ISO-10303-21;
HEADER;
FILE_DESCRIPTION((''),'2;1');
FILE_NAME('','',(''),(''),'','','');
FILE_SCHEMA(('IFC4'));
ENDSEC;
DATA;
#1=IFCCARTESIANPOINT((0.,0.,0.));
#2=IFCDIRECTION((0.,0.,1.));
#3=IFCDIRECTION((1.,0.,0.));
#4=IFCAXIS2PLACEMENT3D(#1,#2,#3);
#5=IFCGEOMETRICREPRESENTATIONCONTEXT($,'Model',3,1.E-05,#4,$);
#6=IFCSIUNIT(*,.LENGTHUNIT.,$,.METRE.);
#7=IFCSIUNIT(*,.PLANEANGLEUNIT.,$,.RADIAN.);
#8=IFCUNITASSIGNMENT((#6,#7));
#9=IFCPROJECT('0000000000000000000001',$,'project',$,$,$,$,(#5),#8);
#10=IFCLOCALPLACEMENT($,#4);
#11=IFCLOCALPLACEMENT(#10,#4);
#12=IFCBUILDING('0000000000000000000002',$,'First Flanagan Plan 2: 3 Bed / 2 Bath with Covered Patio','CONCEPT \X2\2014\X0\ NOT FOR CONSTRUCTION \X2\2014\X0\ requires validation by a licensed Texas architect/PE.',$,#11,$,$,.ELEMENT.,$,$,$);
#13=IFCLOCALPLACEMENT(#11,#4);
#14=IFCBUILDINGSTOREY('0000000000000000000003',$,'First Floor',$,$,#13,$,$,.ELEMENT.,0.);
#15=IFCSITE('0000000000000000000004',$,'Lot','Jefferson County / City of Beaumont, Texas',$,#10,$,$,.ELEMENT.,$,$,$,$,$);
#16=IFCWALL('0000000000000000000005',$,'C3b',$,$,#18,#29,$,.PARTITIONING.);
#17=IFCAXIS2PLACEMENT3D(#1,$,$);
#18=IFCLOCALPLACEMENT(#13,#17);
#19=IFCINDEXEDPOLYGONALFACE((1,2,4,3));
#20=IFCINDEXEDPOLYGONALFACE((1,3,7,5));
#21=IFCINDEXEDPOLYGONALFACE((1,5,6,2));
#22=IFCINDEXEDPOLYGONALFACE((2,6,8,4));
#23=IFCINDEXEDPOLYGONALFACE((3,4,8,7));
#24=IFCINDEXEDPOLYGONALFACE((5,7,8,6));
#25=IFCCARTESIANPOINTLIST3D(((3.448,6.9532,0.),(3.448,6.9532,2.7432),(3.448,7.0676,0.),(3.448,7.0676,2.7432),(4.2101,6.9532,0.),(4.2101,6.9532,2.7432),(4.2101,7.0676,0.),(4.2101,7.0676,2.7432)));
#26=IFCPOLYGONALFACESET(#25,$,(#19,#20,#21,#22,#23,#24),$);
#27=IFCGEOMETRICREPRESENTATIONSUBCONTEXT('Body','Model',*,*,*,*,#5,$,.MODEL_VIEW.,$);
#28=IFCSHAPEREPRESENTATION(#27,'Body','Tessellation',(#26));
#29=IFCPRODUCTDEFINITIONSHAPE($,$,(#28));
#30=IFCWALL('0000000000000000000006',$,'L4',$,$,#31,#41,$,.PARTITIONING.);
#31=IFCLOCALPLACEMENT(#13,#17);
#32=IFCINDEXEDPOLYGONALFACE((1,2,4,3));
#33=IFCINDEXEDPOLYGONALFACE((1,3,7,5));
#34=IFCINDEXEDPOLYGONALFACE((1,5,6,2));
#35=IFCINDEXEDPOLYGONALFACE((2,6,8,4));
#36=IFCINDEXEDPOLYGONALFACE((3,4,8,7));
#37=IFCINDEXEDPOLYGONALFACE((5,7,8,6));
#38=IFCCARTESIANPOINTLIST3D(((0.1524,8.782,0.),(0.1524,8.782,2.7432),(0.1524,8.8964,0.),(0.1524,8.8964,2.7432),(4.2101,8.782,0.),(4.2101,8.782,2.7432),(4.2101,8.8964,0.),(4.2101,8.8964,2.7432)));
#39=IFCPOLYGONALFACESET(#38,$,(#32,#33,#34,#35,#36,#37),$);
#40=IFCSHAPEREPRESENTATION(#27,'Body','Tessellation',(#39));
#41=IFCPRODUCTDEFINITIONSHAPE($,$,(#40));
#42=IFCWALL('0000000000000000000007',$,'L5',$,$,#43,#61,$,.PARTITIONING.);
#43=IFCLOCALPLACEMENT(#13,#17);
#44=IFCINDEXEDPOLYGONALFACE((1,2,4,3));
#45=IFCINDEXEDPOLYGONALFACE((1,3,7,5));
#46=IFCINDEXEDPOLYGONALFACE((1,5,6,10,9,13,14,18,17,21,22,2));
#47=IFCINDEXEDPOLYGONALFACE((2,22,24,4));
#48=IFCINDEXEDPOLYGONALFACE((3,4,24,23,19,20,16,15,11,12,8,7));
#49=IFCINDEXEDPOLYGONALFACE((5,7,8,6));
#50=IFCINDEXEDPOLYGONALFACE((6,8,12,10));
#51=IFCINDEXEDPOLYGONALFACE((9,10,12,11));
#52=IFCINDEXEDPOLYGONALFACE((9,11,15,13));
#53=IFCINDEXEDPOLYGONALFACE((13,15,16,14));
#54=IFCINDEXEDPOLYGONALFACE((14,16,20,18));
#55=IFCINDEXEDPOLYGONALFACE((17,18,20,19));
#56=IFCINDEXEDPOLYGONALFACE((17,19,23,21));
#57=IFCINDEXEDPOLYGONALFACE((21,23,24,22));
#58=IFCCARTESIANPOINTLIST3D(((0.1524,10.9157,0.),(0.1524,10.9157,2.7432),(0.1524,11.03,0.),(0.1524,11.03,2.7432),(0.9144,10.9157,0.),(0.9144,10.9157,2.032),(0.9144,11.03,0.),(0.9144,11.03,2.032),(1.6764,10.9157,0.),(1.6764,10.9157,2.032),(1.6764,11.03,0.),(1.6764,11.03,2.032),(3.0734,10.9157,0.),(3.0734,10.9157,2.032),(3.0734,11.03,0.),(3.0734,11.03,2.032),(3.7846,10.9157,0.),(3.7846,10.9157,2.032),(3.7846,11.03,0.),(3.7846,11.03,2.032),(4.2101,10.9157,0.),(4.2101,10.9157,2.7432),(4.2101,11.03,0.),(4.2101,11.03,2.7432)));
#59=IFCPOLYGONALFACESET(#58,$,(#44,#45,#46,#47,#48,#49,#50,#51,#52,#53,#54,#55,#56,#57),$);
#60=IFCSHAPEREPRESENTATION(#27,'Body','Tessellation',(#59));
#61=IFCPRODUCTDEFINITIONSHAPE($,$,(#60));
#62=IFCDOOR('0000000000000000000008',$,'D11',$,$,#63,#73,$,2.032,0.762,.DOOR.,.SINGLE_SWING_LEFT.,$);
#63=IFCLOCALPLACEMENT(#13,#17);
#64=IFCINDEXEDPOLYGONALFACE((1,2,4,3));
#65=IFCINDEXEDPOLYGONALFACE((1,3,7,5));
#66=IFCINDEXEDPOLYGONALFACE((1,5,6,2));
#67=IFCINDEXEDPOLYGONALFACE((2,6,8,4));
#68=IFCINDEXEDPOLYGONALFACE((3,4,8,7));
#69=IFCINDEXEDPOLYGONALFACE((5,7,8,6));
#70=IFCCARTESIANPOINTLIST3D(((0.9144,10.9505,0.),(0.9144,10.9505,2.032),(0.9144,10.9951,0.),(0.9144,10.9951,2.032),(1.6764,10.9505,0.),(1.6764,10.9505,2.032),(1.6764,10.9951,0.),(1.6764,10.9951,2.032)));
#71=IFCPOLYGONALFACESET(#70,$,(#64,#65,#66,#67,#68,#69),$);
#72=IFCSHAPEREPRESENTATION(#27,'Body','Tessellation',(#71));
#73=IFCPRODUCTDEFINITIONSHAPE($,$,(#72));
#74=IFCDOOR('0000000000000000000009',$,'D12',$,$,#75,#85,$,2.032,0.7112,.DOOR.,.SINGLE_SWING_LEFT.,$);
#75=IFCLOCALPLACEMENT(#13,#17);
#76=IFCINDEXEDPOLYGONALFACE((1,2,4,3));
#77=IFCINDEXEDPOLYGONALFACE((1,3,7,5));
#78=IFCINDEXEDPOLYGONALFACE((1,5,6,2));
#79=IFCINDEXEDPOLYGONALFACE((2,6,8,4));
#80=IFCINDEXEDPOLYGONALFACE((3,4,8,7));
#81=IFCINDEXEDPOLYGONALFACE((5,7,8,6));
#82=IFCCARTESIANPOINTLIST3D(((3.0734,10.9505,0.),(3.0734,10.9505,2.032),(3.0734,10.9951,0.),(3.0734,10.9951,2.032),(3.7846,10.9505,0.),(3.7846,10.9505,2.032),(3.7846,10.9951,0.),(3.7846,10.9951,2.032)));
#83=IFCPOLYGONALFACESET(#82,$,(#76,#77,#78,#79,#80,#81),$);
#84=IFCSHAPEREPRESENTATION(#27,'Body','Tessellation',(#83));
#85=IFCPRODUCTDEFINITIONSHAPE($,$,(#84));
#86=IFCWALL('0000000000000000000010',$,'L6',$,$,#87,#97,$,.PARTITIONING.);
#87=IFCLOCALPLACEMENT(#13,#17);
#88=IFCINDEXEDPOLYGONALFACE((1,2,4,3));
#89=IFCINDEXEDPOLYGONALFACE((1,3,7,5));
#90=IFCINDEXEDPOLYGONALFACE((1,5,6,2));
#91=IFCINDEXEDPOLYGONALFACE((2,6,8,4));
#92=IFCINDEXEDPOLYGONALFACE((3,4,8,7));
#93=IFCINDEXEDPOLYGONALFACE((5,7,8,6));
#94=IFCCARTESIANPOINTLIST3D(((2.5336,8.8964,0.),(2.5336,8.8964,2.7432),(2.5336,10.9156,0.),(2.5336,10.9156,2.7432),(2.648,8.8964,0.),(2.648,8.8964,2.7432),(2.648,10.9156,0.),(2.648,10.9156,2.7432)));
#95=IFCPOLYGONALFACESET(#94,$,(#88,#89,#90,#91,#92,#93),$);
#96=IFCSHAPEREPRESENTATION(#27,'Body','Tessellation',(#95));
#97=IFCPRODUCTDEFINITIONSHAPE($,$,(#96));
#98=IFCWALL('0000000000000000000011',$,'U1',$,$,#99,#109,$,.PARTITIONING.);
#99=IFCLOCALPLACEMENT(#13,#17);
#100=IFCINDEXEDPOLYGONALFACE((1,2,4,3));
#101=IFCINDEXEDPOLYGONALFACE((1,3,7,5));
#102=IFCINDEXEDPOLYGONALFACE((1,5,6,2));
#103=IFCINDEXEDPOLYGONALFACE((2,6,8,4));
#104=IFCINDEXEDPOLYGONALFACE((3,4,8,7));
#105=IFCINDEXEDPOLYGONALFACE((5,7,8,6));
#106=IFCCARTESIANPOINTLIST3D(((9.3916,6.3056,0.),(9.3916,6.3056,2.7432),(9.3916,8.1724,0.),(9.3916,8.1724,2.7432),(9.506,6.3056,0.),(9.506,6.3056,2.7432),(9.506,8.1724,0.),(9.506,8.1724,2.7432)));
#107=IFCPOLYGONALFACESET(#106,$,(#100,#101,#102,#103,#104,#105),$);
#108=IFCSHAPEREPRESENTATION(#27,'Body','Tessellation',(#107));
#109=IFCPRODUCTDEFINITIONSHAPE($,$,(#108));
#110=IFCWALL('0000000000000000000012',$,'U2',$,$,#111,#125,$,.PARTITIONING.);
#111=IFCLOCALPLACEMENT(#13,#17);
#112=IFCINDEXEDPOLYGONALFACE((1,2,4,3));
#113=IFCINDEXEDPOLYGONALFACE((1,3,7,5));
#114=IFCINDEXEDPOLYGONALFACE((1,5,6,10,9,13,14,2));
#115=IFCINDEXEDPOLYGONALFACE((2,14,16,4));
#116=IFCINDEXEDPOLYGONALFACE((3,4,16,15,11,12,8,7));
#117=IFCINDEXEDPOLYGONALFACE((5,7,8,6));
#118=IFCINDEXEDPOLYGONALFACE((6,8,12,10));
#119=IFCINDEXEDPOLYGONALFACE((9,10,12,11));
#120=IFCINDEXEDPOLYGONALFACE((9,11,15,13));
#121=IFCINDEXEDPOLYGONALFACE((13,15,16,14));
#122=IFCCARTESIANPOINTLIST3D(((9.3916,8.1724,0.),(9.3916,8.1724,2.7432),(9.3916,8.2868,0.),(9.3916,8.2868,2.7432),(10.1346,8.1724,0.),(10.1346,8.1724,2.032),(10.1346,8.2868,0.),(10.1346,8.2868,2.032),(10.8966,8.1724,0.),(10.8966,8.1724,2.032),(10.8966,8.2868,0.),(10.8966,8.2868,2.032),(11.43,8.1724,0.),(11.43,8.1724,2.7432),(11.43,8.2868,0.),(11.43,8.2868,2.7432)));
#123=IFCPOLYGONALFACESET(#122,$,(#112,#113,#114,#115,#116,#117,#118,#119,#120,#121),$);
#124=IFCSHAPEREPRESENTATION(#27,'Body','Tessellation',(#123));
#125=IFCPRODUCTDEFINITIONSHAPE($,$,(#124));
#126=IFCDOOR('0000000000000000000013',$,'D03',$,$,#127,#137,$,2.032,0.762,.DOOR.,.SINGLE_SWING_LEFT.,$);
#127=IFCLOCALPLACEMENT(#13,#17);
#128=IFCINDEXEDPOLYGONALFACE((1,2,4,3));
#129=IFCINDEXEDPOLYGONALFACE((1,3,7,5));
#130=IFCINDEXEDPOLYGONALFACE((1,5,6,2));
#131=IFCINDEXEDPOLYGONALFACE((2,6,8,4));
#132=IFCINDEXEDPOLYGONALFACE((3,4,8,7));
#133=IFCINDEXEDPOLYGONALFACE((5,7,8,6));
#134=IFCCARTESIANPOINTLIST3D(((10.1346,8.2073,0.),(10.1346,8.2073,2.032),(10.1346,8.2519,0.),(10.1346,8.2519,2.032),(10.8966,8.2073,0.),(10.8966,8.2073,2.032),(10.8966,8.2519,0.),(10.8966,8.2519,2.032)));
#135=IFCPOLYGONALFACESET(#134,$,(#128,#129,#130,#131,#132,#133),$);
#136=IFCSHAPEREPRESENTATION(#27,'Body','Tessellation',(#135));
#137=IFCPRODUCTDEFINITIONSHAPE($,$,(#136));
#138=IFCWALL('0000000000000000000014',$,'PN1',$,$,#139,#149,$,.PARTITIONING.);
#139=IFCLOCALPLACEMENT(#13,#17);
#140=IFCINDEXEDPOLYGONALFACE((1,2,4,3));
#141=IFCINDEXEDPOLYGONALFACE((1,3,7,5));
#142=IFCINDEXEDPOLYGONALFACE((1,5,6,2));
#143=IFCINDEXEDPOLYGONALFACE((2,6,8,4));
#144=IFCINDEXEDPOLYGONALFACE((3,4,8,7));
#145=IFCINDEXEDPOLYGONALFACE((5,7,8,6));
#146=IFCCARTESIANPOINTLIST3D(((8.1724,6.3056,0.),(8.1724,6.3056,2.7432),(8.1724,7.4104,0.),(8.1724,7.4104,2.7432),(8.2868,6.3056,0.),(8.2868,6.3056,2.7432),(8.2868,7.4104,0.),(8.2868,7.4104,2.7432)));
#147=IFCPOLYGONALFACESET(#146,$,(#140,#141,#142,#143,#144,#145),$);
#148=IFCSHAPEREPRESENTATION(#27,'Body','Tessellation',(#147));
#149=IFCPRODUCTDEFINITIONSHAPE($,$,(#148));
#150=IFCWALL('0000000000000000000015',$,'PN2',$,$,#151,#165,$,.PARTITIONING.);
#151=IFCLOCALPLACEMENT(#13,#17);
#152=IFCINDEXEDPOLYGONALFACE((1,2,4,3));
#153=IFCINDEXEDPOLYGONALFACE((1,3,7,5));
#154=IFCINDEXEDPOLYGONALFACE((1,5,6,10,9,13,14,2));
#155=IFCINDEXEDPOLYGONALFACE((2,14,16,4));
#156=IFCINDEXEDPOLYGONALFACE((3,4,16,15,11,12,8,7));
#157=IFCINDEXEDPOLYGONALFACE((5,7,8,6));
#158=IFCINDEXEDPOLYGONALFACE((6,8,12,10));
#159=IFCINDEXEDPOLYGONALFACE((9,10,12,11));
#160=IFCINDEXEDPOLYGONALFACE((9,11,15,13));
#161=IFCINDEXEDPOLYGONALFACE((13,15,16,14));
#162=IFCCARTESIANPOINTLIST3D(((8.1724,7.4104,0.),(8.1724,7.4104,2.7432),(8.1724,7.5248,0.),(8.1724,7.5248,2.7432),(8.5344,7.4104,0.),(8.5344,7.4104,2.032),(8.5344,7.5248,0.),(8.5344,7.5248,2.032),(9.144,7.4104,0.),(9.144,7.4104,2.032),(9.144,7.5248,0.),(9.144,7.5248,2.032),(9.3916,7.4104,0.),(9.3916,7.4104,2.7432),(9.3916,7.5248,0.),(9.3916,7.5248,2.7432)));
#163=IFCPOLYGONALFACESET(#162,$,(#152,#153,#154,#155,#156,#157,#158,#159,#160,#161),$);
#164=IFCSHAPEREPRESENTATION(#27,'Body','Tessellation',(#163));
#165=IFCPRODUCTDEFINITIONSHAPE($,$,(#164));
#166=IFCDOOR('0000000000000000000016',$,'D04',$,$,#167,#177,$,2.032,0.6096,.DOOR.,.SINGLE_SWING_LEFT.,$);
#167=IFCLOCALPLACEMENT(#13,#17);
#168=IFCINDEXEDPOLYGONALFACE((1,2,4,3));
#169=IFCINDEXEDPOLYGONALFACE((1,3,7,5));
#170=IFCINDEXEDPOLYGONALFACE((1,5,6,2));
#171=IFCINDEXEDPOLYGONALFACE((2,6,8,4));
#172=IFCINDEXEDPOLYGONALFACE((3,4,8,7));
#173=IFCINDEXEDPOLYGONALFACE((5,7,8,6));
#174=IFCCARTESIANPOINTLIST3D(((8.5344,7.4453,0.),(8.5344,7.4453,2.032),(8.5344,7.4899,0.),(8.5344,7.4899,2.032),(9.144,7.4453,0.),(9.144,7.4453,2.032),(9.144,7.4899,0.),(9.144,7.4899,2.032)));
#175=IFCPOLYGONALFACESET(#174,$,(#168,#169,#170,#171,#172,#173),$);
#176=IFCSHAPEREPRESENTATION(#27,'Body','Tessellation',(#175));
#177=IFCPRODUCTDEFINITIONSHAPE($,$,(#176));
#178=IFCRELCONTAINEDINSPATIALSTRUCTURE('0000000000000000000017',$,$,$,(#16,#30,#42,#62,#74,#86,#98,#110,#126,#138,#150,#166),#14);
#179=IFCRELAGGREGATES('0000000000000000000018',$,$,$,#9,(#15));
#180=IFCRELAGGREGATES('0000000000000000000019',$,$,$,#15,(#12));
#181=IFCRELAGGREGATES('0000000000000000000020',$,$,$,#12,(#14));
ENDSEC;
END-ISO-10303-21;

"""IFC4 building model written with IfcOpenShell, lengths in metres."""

from ifc_helpers import new_model, si_unit, frame, frame_2d, origin_with_axes, place, context, subcontext, project, spatial, rectangle, extrude, element, fill, save


model = new_model("IFC4")

# Units and contexts
model_context = context("Model", 3, precision=1e-05, world=origin_with_axes())
body_context = subcontext(model_context, "Body", "Model", "MODEL_VIEW")
ifc_project = project(units=[si_unit("LENGTHUNIT", "METRE"), si_unit("PLANEANGLEUNIT", "RADIAN")], contexts=[model_context])

# Site, building, storey
site_placement = place(None, origin_with_axes())
site = spatial("IfcSite", under=ifc_project, at=site_placement, Name="Lot", Description="Jefferson County / City of Beaumont, Texas", CompositionType="ELEMENT")
building_placement = place(site_placement, origin_with_axes())
building = spatial("IfcBuilding", under=site, at=building_placement, Name="First Flanagan Plan 2: 3 Bed / 2 Bath with Covered Patio", Description="CONCEPT — NOT FOR CONSTRUCTION — requires validation by a licensed Texas architect/PE.", CompositionType="ELEMENT")
storey_placement = place(building_placement, origin_with_axes())
storey = spatial("IfcBuildingStorey", under=building, at=storey_placement, Name="First Floor", CompositionType="ELEMENT", Elevation=0.0)

# Walls
wall_1_placement = place(storey_placement, frame((3.4481, 7.0104, 0.0), z_axis=(0.0, 0.0, 1.0), x_axis=(1.0, 0.0, 0.0)))
element("IfcWall", 1, at=wall_1_placement, inside=storey, Name="C3b", PredefinedType="PARTITIONING", context=body_context, shape_type="SweptSolid", body=[
    extrude(rectangle(XDim=0.762, YDim=0.1143, at=frame_2d((0.381, 0.0), x_axis=(1.0, 0.0))), origin_with_axes(), (0.0, 0.0, 1.0), 2.7432),
])
wall_2_placement = place(storey_placement, frame((0.1524, 8.8392, 0.0), z_axis=(0.0, 0.0, 1.0), x_axis=(1.0, 0.0, 0.0)))
element("IfcWall", 2, at=wall_2_placement, inside=storey, Name="L4", PredefinedType="PARTITIONING", context=body_context, shape_type="SweptSolid", body=[
    extrude(rectangle(XDim=4.0577, YDim=0.1143, at=frame_2d((2.0288, 0.0), x_axis=(1.0, 0.0))), origin_with_axes(), (0.0, 0.0, 1.0), 2.7432),
])

# Wall, openings, doors
wall_3_placement = place(storey_placement, frame((0.1524, 10.9728, 0.0), z_axis=(0.0, 0.0, 1.0), x_axis=(1.0, 0.0, 0.0)))
wall_3 = element("IfcWall", 3, at=wall_3_placement, inside=storey, Name="L5", PredefinedType="PARTITIONING", context=body_context, shape_type="SweptSolid", body=[
    extrude(rectangle(XDim=4.0577, YDim=0.1143, at=frame_2d((2.0288, 0.0), x_axis=(1.0, 0.0))), origin_with_axes(), (0.0, 0.0, 1.0), 2.7432),
])
opening_1_placement = place(wall_3_placement, frame((0.762, 0.0, 0.0), z_axis=(0.0, 0.0, 1.0), x_axis=(1.0, 0.0, 0.0)))
opening_1 = element("IfcOpeningElement", 4, at=opening_1_placement, cuts=wall_3, PredefinedType="OPENING", context=body_context, shape_type="SweptSolid", body=[
    extrude(rectangle(XDim=0.762, YDim=0.1448, at=frame_2d((0.381, 0.0), x_axis=(1.0, 0.0))), origin_with_axes(), (0.0, 0.0, 1.0), 2.032),
])
opening_2_placement = place(wall_3_placement, frame((2.921, 0.0, 0.0), z_axis=(0.0, 0.0, 1.0), x_axis=(1.0, 0.0, 0.0)))
opening_2 = element("IfcOpeningElement", 5, at=opening_2_placement, cuts=wall_3, PredefinedType="OPENING", context=body_context, shape_type="SweptSolid", body=[
    extrude(rectangle(XDim=0.7112, YDim=0.1448, at=frame_2d((0.3556, 0.0), x_axis=(1.0, 0.0))), origin_with_axes(), (0.0, 0.0, 1.0), 2.032),
])
door_1_placement = place(opening_1_placement, origin_with_axes())
door_1 = element("IfcDoor", 6, at=door_1_placement, inside=storey, Name="D11", OperationType="SINGLE_SWING_LEFT", OverallHeight=2.032, OverallWidth=0.762, PredefinedType="DOOR", context=body_context, shape_type="SweptSolid", body=[
    extrude(rectangle(XDim=0.762, YDim=0.0445, at=frame_2d((0.381, 0.0), x_axis=(1.0, 0.0))), origin_with_axes(), (0.0, 0.0, 1.0), 2.032),
])
fill(opening_1, door_1)
door_2_placement = place(opening_2_placement, origin_with_axes())
door_2 = element("IfcDoor", 7, at=door_2_placement, inside=storey, Name="D12", OperationType="SINGLE_SWING_LEFT", OverallHeight=2.032, OverallWidth=0.7112, PredefinedType="DOOR", context=body_context, shape_type="SweptSolid", body=[
    extrude(rectangle(XDim=0.7112, YDim=0.0445, at=frame_2d((0.3556, 0.0), x_axis=(1.0, 0.0))), origin_with_axes(), (0.0, 0.0, 1.0), 2.032),
])
fill(opening_2, door_2)

# Walls
wall_4_placement = place(storey_placement, frame((2.5908, 8.8963, 0.0), z_axis=(0.0, 0.0, 1.0), x_axis=(0.0, 1.0, 0.0)))
element("IfcWall", 8, at=wall_4_placement, inside=storey, Name="L6", PredefinedType="PARTITIONING", context=body_context, shape_type="SweptSolid", body=[
    extrude(rectangle(XDim=2.0193, YDim=0.1143, at=frame_2d((1.0097, 0.0), x_axis=(1.0, 0.0))), origin_with_axes(), (0.0, 0.0, 1.0), 2.7432),
])
wall_5_placement = place(storey_placement, frame((9.4488, 6.3056, 0.0), z_axis=(0.0, 0.0, 1.0), x_axis=(0.0, 1.0, 0.0)))
element("IfcWall", 9, at=wall_5_placement, inside=storey, Name="U1", PredefinedType="PARTITIONING", context=body_context, shape_type="SweptSolid", body=[
    extrude(rectangle(XDim=1.8669, YDim=0.1143, at=frame_2d((0.9335, 0.0), x_axis=(1.0, 0.0))), origin_with_axes(), (0.0, 0.0, 1.0), 2.7432),
])

# Wall, opening, door
wall_6_placement = place(storey_placement, frame((9.3917, 8.2296, 0.0), z_axis=(0.0, 0.0, 1.0), x_axis=(1.0, 0.0, 0.0)))
wall_6 = element("IfcWall", 10, at=wall_6_placement, inside=storey, Name="U2", PredefinedType="PARTITIONING", context=body_context, shape_type="SweptSolid", body=[
    extrude(rectangle(XDim=2.0383, YDim=0.1143, at=frame_2d((1.0192, 0.0), x_axis=(1.0, 0.0))), origin_with_axes(), (0.0, 0.0, 1.0), 2.7432),
])
opening_3_placement = place(wall_6_placement, frame((0.7429, 0.0, 0.0), z_axis=(0.0, 0.0, 1.0), x_axis=(1.0, 0.0, 0.0)))
opening_3 = element("IfcOpeningElement", 11, at=opening_3_placement, cuts=wall_6, PredefinedType="OPENING", context=body_context, shape_type="SweptSolid", body=[
    extrude(rectangle(XDim=0.762, YDim=0.1448, at=frame_2d((0.381, 0.0), x_axis=(1.0, 0.0))), origin_with_axes(), (0.0, 0.0, 1.0), 2.032),
])
door_3_placement = place(opening_3_placement, origin_with_axes())
door_3 = element("IfcDoor", 12, at=door_3_placement, inside=storey, Name="D03", OperationType="SINGLE_SWING_LEFT", OverallHeight=2.032, OverallWidth=0.762, PredefinedType="DOOR", context=body_context, shape_type="SweptSolid", body=[
    extrude(rectangle(XDim=0.762, YDim=0.0445, at=frame_2d((0.381, 0.0), x_axis=(1.0, 0.0))), origin_with_axes(), (0.0, 0.0, 1.0), 2.032),
])
fill(opening_3, door_3)

# Wall
wall_7_placement = place(storey_placement, frame((8.2296, 6.3056, 0.0), z_axis=(0.0, 0.0, 1.0), x_axis=(0.0, 1.0, 0.0)))
element("IfcWall", 13, at=wall_7_placement, inside=storey, Name="PN1", PredefinedType="PARTITIONING", context=body_context, shape_type="SweptSolid", body=[
    extrude(rectangle(XDim=1.1049, YDim=0.1143, at=frame_2d((0.5524, 0.0), x_axis=(1.0, 0.0))), origin_with_axes(), (0.0, 0.0, 1.0), 2.7432),
])

# Wall, opening, door
wall_8_placement = place(storey_placement, frame((8.1724, 7.4676, 0.0), z_axis=(0.0, 0.0, 1.0), x_axis=(1.0, 0.0, 0.0)))
wall_8 = element("IfcWall", 14, at=wall_8_placement, inside=storey, Name="PN2", PredefinedType="PARTITIONING", context=body_context, shape_type="SweptSolid", body=[
    extrude(rectangle(XDim=1.2192, YDim=0.1143, at=frame_2d((0.6096, 0.0), x_axis=(1.0, 0.0))), origin_with_axes(), (0.0, 0.0, 1.0), 2.7432),
])
opening_4_placement = place(wall_8_placement, frame((0.3619, 0.0, 0.0), z_axis=(0.0, 0.0, 1.0), x_axis=(1.0, 0.0, 0.0)))
opening_4 = element("IfcOpeningElement", 15, at=opening_4_placement, cuts=wall_8, PredefinedType="OPENING", context=body_context, shape_type="SweptSolid", body=[
    extrude(rectangle(XDim=0.6096, YDim=0.1448, at=frame_2d((0.3048, 0.0), x_axis=(1.0, 0.0))), origin_with_axes(), (0.0, 0.0, 1.0), 2.032),
])
door_4_placement = place(opening_4_placement, origin_with_axes())
door_4 = element("IfcDoor", 16, at=door_4_placement, inside=storey, Name="D04", OperationType="SINGLE_SWING_LEFT", OverallHeight=2.032, OverallWidth=0.6096, PredefinedType="DOOR", context=body_context, shape_type="SweptSolid", body=[
    extrude(rectangle(XDim=0.6096, YDim=0.0445, at=frame_2d((0.3048, 0.0), x_axis=(1.0, 0.0))), origin_with_axes(), (0.0, 0.0, 1.0), 2.032),
])
fill(opening_4, door_4)

save(model, "model.ifc")
